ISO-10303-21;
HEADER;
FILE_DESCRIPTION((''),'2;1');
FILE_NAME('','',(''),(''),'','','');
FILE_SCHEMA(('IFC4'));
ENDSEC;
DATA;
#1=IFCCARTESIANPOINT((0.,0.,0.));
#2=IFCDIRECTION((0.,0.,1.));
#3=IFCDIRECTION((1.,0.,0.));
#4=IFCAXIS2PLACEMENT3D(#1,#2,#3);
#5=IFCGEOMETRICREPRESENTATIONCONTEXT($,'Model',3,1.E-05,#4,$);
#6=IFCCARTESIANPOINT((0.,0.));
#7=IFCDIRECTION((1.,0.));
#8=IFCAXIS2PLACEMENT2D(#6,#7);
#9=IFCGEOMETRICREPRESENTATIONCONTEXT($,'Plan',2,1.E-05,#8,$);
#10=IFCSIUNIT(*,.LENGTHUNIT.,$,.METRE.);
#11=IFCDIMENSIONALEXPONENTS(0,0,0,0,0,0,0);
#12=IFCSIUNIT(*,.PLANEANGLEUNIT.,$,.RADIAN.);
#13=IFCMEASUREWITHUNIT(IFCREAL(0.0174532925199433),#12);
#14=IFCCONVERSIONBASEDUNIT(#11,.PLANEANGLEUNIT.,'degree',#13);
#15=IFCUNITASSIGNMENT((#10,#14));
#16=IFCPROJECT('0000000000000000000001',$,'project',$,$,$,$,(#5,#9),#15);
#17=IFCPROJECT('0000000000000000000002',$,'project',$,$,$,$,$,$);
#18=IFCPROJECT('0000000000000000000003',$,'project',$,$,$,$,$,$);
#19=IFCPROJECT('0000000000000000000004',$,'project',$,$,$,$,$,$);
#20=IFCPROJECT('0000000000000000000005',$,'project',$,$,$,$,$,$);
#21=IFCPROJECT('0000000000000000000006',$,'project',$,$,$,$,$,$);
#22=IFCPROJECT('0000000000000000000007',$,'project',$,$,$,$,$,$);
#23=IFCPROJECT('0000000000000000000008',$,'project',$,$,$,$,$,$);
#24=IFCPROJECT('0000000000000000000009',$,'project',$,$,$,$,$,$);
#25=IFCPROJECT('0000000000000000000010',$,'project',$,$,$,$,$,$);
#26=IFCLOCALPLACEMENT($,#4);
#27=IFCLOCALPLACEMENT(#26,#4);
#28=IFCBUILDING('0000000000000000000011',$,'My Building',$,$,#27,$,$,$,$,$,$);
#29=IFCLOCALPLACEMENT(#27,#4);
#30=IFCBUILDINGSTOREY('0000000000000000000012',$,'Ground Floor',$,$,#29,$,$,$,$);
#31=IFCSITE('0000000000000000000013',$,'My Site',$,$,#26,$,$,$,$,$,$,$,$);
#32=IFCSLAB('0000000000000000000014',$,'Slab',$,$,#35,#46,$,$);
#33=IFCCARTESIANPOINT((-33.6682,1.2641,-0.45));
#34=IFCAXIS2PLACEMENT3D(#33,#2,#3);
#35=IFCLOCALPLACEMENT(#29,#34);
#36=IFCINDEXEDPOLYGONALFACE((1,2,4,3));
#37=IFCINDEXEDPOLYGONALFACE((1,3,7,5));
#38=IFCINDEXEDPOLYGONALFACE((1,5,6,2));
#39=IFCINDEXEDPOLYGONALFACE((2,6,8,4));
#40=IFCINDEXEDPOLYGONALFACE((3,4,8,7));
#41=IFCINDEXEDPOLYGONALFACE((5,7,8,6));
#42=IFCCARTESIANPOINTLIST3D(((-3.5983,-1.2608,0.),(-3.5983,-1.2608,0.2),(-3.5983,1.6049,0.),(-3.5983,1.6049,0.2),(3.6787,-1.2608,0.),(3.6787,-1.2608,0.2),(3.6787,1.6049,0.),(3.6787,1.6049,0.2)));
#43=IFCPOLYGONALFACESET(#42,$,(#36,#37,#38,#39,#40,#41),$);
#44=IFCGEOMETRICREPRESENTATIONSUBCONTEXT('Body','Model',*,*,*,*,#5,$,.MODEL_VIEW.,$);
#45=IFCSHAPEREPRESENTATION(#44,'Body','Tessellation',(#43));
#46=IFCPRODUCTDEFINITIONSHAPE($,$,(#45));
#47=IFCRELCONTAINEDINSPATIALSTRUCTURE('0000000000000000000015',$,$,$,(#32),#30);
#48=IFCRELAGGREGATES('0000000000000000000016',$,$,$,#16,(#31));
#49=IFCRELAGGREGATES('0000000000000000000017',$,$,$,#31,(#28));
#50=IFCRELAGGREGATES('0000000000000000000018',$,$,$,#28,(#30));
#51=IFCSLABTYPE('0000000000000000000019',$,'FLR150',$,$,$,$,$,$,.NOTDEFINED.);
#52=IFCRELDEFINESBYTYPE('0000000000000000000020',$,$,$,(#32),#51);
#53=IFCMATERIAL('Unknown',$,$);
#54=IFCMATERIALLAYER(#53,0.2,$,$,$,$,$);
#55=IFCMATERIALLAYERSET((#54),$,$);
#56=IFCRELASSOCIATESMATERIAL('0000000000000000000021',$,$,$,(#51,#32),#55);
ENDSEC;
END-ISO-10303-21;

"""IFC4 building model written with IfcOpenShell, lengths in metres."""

from ifc_helpers import new_model, entity, si_unit, converted_unit, frame, origin_with_axes, origin_2d_with_axis, place, context, subcontext, project, spatial, line, indexed_curve, outline, extrude, material, layer, layer_set, layer_usage, type_object, element, save


model = new_model("IFC4")

# Units and contexts
model_context = context("Model", 3, precision=1e-05, world=origin_with_axes())
plan_context = context("Plan", 2, precision=1e-05, world=origin_2d_with_axis())
body_context_1 = subcontext(model_context, "Body", "Model", "MODEL_VIEW")
ifc_project_1 = project(units=[si_unit("LENGTHUNIT", "METRE"), converted_unit("PLANEANGLEUNIT", "degree", entity("IfcReal", 0.0174532925199433), si_unit("PLANEANGLEUNIT", "RADIAN"), dimensions=[0, 0, 0, 0, 0, 0, 0])], contexts=[model_context, plan_context])
ifc_project_2 = project()
ifc_project_3 = project()
ifc_project_4 = project()
ifc_project_5 = project()
ifc_project_6 = project()
ifc_project_7 = project()
ifc_project_8 = project()
ifc_project_9 = project()
ifc_project_10 = project()

# Site, building, storey
site_placement = place(None, origin_with_axes())
site = spatial("IfcSite", under=ifc_project_1, at=site_placement, Name="My Site")
building_placement = place(site_placement, origin_with_axes())
building = spatial("IfcBuilding", under=site, at=building_placement, Name="My Building")
storey_placement = place(building_placement, origin_with_axes())
storey = spatial("IfcBuildingStorey", under=building, at=storey_placement, Name="Ground Floor")

# Shared definitions
ifc_material = material(Name="Unknown")

# Slab
ifc_layer_1 = layer(ifc_material, 0.2)
ifc_layer_set_1 = layer_set([ifc_layer_1])
slab_type = type_object("IfcSlabType", Name="FLR150", PredefinedType="NOTDEFINED", material=ifc_layer_set_1)
ifc_layer_usage_1 = layer_usage(ifc_layer_set_1, "AXIS3", "POSITIVE", 0.0)
slab_1_placement = place(storey_placement, frame((-33.6682, 1.2641, -0.45), z_axis=(0.0, 0.0, 1.0), x_axis=(1.0, 0.0, 0.0)))
element("IfcSlab", 1, at=slab_1_placement, inside=storey, type_object=slab_type, material=ifc_layer_usage_1, Name="Slab", context=body_context_1, shape_type="SweptSolid", body=[
    extrude(outline(indexed_curve([(-3.5983, -1.2608), (3.6787, -1.2608), (3.6787, 1.6049), (-3.5983, 1.6049)], segments=[line(3, 2), line(2, 1), line(1, 4), line(4, 3)], self_intersect=False)), None, (0.0, 0.0, 1.0), 0.2),
])

save(model, "model.ifc")
